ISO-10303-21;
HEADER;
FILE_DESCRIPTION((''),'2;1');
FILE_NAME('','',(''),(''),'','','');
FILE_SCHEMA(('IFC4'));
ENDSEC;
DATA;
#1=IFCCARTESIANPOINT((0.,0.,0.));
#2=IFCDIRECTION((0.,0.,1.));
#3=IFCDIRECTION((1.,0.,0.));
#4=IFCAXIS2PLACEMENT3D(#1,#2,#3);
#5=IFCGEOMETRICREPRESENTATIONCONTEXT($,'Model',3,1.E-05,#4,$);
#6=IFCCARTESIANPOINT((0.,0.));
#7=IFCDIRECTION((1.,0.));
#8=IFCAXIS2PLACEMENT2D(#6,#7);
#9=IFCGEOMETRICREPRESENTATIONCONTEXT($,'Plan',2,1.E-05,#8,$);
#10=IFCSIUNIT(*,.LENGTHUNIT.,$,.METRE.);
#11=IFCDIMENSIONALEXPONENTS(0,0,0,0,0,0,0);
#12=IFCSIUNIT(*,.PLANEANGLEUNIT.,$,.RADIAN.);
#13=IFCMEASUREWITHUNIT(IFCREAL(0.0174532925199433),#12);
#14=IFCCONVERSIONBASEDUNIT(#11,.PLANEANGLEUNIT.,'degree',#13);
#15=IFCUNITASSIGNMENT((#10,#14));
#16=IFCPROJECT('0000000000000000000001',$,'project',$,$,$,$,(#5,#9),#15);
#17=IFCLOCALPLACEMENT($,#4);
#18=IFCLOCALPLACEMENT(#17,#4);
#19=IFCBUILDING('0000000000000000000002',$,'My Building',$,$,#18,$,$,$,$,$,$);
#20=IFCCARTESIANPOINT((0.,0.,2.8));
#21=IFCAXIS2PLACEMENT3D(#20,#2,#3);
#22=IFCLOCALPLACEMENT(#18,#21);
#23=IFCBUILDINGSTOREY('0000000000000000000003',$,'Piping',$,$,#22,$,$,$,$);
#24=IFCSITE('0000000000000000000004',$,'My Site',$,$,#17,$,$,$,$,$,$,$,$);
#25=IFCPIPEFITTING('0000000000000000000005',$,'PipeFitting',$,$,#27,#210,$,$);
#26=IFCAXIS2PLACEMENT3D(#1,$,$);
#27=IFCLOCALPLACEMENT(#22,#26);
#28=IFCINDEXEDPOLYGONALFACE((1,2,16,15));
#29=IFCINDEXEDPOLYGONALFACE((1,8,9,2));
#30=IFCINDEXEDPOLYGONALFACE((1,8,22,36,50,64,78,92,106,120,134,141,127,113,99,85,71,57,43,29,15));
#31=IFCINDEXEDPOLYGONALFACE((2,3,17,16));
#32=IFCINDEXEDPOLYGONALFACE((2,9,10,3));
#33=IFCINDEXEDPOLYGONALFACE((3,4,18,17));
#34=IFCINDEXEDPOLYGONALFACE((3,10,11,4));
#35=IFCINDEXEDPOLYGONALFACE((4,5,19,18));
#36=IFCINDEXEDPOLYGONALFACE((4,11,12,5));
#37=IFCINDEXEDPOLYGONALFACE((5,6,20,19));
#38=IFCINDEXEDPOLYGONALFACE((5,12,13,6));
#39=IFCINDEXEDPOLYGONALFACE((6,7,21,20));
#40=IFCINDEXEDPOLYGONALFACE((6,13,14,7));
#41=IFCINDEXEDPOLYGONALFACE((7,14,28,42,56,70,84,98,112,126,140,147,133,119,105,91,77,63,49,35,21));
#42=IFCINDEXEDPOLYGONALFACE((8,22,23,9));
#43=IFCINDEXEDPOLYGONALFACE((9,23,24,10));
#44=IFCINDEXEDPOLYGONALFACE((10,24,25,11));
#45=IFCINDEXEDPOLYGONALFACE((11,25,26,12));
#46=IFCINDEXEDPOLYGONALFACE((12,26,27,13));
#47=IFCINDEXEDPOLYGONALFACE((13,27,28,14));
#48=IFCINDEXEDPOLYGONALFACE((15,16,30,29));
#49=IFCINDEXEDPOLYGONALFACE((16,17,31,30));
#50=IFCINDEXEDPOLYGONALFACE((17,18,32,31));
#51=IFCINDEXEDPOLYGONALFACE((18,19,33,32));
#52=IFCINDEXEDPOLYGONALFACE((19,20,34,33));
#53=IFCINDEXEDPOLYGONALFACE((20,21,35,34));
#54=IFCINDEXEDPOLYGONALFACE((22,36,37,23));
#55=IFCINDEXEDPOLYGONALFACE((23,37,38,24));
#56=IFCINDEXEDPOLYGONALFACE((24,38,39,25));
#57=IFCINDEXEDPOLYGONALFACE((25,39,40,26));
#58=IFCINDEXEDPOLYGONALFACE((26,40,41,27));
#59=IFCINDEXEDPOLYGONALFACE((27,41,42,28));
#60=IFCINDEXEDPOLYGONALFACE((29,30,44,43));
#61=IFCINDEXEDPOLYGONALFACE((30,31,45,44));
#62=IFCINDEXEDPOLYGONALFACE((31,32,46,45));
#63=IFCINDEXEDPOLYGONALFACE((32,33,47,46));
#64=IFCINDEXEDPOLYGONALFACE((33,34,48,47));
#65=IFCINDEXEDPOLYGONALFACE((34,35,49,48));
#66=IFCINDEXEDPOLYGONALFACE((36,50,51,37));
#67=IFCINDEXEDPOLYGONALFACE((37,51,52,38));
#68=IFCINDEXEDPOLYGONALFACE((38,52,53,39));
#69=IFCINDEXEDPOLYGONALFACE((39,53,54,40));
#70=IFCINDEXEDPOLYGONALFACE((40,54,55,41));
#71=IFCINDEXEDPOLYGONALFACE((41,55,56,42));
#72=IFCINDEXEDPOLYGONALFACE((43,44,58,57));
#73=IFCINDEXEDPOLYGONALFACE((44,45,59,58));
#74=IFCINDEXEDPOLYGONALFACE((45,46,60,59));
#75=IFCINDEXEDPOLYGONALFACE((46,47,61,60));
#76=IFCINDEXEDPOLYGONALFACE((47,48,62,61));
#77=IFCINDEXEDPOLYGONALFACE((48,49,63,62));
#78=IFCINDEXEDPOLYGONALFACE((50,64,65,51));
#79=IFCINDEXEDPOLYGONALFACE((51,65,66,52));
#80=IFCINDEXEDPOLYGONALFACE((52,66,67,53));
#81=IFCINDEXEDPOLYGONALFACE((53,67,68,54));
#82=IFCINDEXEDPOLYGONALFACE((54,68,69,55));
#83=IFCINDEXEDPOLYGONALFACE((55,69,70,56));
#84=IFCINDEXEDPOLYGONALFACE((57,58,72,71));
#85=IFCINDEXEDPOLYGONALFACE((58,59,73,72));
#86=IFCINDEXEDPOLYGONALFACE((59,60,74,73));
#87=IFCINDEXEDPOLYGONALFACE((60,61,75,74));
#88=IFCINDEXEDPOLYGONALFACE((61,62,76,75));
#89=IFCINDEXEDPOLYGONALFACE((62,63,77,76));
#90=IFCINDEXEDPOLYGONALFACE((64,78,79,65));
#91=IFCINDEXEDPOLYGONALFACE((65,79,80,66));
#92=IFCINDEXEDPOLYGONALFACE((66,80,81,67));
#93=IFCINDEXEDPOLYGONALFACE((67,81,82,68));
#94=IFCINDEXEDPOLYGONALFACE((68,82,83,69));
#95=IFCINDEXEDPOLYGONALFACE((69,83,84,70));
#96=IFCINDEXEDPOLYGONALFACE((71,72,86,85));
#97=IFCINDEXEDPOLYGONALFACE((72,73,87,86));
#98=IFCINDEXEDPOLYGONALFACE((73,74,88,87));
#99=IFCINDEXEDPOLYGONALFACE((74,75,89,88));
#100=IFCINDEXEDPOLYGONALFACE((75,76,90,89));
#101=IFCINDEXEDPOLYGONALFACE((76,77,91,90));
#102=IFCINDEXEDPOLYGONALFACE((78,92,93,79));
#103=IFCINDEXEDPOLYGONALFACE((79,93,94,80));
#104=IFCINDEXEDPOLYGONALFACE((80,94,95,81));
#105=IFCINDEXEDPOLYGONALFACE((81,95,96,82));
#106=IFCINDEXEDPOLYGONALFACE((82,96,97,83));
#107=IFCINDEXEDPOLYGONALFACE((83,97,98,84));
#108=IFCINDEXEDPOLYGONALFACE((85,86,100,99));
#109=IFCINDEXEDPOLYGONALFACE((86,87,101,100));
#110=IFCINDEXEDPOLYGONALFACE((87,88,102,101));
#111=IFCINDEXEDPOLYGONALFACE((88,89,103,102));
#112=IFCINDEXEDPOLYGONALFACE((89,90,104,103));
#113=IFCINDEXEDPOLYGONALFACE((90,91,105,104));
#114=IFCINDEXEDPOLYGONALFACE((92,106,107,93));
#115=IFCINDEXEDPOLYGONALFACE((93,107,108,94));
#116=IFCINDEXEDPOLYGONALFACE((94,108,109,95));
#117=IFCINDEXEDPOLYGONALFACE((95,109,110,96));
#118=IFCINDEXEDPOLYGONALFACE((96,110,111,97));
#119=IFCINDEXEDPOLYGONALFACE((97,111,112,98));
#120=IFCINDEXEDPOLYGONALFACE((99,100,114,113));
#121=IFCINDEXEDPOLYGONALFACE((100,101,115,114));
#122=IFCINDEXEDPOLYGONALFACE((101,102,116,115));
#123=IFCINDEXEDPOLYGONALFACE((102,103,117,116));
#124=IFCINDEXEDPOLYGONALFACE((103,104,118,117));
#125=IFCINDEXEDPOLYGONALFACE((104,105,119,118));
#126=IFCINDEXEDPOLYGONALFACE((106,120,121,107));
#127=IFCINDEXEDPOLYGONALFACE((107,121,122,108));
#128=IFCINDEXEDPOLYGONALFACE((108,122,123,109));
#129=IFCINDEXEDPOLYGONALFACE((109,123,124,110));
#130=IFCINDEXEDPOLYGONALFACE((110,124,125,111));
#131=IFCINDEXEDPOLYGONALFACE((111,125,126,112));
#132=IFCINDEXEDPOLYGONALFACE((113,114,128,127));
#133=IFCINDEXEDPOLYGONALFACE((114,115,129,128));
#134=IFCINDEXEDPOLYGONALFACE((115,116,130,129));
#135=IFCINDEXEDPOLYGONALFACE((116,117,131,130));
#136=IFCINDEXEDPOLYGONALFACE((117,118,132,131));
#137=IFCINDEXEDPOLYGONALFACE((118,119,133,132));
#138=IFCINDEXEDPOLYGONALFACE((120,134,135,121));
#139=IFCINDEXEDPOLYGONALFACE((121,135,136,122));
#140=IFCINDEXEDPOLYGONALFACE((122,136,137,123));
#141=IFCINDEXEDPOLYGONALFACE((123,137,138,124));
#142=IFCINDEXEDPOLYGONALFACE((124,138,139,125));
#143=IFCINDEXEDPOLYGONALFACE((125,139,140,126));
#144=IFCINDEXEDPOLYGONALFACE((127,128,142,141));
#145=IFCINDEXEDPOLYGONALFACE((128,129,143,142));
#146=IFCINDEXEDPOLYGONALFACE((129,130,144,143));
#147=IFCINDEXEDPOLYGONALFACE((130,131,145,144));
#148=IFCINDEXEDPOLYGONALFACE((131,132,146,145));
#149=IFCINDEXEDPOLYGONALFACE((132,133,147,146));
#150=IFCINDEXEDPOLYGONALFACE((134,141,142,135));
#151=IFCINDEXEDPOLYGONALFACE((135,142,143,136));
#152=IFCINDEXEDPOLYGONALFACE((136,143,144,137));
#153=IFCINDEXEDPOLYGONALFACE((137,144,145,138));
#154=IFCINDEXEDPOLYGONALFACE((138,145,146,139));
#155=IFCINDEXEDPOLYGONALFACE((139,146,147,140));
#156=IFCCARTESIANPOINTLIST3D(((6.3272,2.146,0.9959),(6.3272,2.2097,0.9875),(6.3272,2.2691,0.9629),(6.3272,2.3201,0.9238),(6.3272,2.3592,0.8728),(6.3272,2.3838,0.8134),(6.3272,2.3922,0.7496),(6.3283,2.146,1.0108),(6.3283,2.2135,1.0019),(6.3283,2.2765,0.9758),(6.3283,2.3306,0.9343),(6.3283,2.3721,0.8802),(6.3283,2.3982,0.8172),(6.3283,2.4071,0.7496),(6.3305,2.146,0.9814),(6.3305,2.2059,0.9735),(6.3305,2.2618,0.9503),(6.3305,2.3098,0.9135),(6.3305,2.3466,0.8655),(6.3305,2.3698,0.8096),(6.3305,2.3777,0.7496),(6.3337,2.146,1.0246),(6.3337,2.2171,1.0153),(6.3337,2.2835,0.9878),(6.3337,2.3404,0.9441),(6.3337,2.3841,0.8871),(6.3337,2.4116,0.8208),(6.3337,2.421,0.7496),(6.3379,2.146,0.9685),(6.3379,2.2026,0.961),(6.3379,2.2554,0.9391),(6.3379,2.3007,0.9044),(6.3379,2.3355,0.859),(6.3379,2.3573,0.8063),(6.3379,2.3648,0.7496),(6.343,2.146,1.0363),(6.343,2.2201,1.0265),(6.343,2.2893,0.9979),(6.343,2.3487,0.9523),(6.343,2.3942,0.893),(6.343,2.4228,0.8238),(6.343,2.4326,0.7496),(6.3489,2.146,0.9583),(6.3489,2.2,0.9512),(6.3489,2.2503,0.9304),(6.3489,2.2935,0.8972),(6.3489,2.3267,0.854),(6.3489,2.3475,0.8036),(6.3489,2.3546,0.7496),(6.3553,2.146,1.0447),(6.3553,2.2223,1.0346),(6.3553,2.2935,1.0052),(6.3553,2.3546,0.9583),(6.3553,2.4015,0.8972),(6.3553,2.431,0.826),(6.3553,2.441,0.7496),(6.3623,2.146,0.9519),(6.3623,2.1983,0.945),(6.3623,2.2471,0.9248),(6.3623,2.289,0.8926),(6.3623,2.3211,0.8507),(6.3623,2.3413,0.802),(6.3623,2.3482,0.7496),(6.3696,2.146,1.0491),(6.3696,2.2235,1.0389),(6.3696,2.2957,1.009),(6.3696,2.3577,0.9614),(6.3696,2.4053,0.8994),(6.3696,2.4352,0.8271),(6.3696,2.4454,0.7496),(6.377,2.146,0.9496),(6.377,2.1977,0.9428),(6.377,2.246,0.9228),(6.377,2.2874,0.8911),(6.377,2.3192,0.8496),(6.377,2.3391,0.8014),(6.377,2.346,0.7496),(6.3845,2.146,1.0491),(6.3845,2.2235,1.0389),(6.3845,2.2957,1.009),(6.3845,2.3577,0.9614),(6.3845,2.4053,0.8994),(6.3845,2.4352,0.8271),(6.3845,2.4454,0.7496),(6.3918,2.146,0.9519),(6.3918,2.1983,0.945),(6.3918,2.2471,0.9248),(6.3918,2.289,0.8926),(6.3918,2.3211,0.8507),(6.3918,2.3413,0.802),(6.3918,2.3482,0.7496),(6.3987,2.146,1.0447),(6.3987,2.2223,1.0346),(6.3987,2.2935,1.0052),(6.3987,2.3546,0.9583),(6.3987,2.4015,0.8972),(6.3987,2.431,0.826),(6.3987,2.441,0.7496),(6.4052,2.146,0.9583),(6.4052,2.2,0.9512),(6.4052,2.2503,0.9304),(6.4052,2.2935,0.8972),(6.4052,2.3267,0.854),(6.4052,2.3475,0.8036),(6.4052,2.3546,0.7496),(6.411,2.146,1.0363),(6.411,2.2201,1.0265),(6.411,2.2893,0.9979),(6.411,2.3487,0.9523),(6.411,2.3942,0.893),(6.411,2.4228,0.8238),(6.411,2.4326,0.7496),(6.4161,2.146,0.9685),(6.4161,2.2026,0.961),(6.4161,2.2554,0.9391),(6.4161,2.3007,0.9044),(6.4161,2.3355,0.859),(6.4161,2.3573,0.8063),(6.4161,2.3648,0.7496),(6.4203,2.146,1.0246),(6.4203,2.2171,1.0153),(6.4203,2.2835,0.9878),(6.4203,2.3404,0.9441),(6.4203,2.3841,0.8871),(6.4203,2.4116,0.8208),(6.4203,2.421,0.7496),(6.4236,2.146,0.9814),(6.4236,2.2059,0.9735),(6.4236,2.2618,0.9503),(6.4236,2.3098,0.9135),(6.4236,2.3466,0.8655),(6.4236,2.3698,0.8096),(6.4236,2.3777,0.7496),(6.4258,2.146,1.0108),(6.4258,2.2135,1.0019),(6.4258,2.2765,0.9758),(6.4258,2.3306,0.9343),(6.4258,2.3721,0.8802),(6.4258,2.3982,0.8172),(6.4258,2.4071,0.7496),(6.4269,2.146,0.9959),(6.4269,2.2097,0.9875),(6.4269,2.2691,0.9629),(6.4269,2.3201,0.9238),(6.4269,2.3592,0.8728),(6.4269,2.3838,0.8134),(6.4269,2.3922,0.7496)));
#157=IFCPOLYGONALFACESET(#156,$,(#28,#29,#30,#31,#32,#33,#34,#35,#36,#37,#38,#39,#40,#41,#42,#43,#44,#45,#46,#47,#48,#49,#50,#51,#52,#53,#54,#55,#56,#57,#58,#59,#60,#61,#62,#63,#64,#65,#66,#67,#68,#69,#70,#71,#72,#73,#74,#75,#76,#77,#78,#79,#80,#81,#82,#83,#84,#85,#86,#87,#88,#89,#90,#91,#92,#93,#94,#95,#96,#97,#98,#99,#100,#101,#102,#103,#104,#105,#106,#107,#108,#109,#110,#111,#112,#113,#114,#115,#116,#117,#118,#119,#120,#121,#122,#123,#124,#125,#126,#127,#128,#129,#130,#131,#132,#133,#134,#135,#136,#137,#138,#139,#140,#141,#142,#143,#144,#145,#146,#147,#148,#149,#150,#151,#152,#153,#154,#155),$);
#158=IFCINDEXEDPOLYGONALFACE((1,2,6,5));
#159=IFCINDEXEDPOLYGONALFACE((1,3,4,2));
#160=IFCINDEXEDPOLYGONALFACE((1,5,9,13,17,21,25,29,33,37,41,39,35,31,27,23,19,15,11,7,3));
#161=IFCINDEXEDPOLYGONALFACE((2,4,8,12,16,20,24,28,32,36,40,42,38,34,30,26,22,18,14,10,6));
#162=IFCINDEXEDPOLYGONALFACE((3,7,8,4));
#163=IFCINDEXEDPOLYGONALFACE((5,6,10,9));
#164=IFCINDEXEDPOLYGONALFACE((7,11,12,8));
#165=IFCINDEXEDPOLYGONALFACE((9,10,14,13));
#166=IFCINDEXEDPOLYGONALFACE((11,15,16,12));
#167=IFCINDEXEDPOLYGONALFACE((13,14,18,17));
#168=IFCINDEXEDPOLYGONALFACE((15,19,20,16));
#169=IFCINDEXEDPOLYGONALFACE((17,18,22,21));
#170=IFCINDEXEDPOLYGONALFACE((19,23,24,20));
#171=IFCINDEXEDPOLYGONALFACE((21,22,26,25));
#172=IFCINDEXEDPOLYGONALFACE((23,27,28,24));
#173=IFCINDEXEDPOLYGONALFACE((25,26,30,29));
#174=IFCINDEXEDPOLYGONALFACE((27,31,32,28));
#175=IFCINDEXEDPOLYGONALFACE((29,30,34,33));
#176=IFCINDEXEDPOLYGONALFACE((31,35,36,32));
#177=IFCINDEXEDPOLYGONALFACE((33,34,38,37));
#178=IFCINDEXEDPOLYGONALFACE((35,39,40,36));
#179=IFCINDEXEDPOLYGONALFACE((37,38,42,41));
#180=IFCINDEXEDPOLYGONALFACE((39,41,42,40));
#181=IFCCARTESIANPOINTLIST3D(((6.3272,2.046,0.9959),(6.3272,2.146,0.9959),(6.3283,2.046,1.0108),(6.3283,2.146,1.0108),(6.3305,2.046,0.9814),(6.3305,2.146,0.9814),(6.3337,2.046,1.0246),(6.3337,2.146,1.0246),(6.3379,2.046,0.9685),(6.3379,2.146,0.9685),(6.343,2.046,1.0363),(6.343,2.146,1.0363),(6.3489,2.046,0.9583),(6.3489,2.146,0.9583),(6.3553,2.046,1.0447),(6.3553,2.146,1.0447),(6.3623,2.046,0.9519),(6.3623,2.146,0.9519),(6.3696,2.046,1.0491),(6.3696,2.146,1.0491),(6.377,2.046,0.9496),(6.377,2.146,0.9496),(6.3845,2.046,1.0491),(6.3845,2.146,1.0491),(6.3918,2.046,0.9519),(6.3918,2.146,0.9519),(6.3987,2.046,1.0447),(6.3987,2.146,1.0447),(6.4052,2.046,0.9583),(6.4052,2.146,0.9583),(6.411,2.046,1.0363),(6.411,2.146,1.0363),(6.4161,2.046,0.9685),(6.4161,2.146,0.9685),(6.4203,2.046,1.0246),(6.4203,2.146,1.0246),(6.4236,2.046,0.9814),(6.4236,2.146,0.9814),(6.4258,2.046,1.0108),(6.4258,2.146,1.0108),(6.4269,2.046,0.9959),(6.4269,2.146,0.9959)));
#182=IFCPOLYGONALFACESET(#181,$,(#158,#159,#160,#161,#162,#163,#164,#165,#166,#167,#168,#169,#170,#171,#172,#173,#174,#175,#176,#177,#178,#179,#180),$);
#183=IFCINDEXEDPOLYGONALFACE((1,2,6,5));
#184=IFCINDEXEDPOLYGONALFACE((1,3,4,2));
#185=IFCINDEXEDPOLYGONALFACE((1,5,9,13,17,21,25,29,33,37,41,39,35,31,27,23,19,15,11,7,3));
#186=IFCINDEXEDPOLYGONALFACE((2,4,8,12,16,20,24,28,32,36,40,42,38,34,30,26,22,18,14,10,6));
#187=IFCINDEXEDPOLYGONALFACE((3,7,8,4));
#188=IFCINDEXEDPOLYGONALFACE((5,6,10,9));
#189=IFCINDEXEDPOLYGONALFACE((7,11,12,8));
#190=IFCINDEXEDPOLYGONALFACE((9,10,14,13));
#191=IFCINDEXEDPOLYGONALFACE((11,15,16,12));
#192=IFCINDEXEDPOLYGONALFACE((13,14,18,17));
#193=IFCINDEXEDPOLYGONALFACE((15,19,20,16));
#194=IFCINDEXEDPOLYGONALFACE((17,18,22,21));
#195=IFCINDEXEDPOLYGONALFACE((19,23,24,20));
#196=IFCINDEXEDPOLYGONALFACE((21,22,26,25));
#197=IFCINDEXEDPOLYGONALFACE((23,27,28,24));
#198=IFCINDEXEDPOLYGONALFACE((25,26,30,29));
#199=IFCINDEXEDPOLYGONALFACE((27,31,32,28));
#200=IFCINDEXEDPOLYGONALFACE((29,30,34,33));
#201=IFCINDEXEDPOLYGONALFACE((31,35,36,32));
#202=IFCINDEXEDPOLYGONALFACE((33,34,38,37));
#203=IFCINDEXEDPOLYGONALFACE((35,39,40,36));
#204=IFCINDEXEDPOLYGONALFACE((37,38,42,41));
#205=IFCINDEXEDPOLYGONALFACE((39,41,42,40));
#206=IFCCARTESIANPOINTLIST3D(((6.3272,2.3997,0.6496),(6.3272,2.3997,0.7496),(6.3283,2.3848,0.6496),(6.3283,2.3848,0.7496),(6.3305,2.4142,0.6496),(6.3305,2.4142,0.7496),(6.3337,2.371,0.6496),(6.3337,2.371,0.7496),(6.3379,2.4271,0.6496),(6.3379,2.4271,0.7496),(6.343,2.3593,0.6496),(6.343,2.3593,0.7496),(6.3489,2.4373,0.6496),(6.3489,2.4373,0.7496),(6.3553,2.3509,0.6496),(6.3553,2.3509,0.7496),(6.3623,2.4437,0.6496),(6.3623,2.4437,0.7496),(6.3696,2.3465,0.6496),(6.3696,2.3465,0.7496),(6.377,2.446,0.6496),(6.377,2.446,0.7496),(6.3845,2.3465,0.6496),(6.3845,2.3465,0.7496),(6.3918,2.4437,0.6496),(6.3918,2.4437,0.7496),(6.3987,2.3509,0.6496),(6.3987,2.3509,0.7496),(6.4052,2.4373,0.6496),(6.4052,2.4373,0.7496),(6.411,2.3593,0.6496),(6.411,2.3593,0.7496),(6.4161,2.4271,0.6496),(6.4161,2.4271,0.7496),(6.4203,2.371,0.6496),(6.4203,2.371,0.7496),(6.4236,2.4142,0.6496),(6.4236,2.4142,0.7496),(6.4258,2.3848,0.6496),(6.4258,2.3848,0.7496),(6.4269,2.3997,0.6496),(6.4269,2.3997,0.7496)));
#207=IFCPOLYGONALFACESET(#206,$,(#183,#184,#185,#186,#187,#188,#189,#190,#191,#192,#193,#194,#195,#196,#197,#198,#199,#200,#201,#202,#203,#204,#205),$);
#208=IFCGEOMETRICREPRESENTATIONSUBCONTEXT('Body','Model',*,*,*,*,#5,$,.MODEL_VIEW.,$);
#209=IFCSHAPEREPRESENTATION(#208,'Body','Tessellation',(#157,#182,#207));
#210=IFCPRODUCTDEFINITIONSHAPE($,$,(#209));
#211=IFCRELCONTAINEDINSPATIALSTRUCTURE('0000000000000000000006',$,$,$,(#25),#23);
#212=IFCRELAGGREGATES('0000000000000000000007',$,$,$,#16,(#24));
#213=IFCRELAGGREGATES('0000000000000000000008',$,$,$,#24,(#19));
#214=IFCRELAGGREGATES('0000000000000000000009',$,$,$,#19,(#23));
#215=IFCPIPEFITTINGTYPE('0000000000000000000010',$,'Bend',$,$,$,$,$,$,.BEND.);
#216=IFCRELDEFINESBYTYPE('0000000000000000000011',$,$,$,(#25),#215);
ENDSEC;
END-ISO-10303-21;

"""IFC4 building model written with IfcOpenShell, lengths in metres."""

from ifc_helpers import new_model, entity, si_unit, converted_unit, frame, origin_with_axes, origin_2d_with_axis, place, context, subcontext, project, spatial, circle, extrude, source, transform, mapped, type_object, type_shapes, element, save


model = new_model("IFC4")

# Units and contexts
model_context = context("Model", 3, precision=1e-05, world=origin_with_axes())
plan_context = context("Plan", 2, precision=1e-05, world=origin_2d_with_axis())
body_context = subcontext(model_context, "Body", "Model", "MODEL_VIEW")
ifc_project = project(units=[si_unit("LENGTHUNIT", "METRE"), converted_unit("PLANEANGLEUNIT", "degree", entity("IfcReal", 0.0174532925199433), si_unit("PLANEANGLEUNIT", "RADIAN"), dimensions=[0, 0, 0, 0, 0, 0, 0])], contexts=[model_context, plan_context])

# Site, building, storey
site_placement = place(None, origin_with_axes())
site = spatial("IfcSite", under=ifc_project, at=site_placement, Name="My Site")
building_placement = place(site_placement, origin_with_axes())
building = spatial("IfcBuilding", under=site, at=building_placement, Name="My Building")
storey_placement = place(building_placement, frame((0.0, 0.0, 2.8), z_axis=(0.0, 0.0, 1.0), x_axis=(1.0, 0.0, 0.0)))
storey = spatial("IfcBuildingStorey", under=building, at=storey_placement, Name="Piping")

# Pipe fitting
pipe_fitting_type_1 = type_object("IfcPipeFittingType", Name="Bend", PredefinedType="BEND")
shared_shape = source(origin_with_axes(), body_context, "Body", "SolidModel", [
    entity("IfcSweptDiskSolid", entity("IfcIndexedPolyCurve", entity("IfcCartesianPointList3D", [[0.0, 0.0, 0.1], [0.0732, 0.0, 0.2768], [0.25, 0.0, 0.35]]), [entity("IfcArcIndex", [1, 2, 3])]), 0.05),
    extrude(circle(Radius=0.05), origin_with_axes(), (0.0, 0.0, 1.0), 0.1),
    extrude(circle(Radius=0.05), frame((0.25, 0.0, 0.35), z_axis=(1.0, 0.0, 0.0), x_axis=(0.0, 0.0, 1.0)), (0.0, 0.0, 1.0), 0.1),
])
type_shapes(pipe_fitting_type_1, [shared_shape])
for number, where, z_axis, x_axis, name in (
    (1, (6.377, 2.046, 0.9996), (0.0, 1.0, 0.0), (0.0, 0.0, -1.0), "PipeFitting"),
):
    element("IfcPipeFitting", number, at=place(storey_placement, frame(where, z_axis=z_axis, x_axis=x_axis)), inside=storey, type_object=pipe_fitting_type_1, Name=name, context=body_context, shape_type="MappedRepresentation", body=[
        mapped(shared_shape, transform((0.0, 0.0, 0.0), x_axis=(1.0, 0.0, 0.0), y_axis=(0.0, 1.0, 0.0), z_axis=(0.0, 0.0, 1.0), scale=1.0)),
    ])

save(model, "model.ifc")
